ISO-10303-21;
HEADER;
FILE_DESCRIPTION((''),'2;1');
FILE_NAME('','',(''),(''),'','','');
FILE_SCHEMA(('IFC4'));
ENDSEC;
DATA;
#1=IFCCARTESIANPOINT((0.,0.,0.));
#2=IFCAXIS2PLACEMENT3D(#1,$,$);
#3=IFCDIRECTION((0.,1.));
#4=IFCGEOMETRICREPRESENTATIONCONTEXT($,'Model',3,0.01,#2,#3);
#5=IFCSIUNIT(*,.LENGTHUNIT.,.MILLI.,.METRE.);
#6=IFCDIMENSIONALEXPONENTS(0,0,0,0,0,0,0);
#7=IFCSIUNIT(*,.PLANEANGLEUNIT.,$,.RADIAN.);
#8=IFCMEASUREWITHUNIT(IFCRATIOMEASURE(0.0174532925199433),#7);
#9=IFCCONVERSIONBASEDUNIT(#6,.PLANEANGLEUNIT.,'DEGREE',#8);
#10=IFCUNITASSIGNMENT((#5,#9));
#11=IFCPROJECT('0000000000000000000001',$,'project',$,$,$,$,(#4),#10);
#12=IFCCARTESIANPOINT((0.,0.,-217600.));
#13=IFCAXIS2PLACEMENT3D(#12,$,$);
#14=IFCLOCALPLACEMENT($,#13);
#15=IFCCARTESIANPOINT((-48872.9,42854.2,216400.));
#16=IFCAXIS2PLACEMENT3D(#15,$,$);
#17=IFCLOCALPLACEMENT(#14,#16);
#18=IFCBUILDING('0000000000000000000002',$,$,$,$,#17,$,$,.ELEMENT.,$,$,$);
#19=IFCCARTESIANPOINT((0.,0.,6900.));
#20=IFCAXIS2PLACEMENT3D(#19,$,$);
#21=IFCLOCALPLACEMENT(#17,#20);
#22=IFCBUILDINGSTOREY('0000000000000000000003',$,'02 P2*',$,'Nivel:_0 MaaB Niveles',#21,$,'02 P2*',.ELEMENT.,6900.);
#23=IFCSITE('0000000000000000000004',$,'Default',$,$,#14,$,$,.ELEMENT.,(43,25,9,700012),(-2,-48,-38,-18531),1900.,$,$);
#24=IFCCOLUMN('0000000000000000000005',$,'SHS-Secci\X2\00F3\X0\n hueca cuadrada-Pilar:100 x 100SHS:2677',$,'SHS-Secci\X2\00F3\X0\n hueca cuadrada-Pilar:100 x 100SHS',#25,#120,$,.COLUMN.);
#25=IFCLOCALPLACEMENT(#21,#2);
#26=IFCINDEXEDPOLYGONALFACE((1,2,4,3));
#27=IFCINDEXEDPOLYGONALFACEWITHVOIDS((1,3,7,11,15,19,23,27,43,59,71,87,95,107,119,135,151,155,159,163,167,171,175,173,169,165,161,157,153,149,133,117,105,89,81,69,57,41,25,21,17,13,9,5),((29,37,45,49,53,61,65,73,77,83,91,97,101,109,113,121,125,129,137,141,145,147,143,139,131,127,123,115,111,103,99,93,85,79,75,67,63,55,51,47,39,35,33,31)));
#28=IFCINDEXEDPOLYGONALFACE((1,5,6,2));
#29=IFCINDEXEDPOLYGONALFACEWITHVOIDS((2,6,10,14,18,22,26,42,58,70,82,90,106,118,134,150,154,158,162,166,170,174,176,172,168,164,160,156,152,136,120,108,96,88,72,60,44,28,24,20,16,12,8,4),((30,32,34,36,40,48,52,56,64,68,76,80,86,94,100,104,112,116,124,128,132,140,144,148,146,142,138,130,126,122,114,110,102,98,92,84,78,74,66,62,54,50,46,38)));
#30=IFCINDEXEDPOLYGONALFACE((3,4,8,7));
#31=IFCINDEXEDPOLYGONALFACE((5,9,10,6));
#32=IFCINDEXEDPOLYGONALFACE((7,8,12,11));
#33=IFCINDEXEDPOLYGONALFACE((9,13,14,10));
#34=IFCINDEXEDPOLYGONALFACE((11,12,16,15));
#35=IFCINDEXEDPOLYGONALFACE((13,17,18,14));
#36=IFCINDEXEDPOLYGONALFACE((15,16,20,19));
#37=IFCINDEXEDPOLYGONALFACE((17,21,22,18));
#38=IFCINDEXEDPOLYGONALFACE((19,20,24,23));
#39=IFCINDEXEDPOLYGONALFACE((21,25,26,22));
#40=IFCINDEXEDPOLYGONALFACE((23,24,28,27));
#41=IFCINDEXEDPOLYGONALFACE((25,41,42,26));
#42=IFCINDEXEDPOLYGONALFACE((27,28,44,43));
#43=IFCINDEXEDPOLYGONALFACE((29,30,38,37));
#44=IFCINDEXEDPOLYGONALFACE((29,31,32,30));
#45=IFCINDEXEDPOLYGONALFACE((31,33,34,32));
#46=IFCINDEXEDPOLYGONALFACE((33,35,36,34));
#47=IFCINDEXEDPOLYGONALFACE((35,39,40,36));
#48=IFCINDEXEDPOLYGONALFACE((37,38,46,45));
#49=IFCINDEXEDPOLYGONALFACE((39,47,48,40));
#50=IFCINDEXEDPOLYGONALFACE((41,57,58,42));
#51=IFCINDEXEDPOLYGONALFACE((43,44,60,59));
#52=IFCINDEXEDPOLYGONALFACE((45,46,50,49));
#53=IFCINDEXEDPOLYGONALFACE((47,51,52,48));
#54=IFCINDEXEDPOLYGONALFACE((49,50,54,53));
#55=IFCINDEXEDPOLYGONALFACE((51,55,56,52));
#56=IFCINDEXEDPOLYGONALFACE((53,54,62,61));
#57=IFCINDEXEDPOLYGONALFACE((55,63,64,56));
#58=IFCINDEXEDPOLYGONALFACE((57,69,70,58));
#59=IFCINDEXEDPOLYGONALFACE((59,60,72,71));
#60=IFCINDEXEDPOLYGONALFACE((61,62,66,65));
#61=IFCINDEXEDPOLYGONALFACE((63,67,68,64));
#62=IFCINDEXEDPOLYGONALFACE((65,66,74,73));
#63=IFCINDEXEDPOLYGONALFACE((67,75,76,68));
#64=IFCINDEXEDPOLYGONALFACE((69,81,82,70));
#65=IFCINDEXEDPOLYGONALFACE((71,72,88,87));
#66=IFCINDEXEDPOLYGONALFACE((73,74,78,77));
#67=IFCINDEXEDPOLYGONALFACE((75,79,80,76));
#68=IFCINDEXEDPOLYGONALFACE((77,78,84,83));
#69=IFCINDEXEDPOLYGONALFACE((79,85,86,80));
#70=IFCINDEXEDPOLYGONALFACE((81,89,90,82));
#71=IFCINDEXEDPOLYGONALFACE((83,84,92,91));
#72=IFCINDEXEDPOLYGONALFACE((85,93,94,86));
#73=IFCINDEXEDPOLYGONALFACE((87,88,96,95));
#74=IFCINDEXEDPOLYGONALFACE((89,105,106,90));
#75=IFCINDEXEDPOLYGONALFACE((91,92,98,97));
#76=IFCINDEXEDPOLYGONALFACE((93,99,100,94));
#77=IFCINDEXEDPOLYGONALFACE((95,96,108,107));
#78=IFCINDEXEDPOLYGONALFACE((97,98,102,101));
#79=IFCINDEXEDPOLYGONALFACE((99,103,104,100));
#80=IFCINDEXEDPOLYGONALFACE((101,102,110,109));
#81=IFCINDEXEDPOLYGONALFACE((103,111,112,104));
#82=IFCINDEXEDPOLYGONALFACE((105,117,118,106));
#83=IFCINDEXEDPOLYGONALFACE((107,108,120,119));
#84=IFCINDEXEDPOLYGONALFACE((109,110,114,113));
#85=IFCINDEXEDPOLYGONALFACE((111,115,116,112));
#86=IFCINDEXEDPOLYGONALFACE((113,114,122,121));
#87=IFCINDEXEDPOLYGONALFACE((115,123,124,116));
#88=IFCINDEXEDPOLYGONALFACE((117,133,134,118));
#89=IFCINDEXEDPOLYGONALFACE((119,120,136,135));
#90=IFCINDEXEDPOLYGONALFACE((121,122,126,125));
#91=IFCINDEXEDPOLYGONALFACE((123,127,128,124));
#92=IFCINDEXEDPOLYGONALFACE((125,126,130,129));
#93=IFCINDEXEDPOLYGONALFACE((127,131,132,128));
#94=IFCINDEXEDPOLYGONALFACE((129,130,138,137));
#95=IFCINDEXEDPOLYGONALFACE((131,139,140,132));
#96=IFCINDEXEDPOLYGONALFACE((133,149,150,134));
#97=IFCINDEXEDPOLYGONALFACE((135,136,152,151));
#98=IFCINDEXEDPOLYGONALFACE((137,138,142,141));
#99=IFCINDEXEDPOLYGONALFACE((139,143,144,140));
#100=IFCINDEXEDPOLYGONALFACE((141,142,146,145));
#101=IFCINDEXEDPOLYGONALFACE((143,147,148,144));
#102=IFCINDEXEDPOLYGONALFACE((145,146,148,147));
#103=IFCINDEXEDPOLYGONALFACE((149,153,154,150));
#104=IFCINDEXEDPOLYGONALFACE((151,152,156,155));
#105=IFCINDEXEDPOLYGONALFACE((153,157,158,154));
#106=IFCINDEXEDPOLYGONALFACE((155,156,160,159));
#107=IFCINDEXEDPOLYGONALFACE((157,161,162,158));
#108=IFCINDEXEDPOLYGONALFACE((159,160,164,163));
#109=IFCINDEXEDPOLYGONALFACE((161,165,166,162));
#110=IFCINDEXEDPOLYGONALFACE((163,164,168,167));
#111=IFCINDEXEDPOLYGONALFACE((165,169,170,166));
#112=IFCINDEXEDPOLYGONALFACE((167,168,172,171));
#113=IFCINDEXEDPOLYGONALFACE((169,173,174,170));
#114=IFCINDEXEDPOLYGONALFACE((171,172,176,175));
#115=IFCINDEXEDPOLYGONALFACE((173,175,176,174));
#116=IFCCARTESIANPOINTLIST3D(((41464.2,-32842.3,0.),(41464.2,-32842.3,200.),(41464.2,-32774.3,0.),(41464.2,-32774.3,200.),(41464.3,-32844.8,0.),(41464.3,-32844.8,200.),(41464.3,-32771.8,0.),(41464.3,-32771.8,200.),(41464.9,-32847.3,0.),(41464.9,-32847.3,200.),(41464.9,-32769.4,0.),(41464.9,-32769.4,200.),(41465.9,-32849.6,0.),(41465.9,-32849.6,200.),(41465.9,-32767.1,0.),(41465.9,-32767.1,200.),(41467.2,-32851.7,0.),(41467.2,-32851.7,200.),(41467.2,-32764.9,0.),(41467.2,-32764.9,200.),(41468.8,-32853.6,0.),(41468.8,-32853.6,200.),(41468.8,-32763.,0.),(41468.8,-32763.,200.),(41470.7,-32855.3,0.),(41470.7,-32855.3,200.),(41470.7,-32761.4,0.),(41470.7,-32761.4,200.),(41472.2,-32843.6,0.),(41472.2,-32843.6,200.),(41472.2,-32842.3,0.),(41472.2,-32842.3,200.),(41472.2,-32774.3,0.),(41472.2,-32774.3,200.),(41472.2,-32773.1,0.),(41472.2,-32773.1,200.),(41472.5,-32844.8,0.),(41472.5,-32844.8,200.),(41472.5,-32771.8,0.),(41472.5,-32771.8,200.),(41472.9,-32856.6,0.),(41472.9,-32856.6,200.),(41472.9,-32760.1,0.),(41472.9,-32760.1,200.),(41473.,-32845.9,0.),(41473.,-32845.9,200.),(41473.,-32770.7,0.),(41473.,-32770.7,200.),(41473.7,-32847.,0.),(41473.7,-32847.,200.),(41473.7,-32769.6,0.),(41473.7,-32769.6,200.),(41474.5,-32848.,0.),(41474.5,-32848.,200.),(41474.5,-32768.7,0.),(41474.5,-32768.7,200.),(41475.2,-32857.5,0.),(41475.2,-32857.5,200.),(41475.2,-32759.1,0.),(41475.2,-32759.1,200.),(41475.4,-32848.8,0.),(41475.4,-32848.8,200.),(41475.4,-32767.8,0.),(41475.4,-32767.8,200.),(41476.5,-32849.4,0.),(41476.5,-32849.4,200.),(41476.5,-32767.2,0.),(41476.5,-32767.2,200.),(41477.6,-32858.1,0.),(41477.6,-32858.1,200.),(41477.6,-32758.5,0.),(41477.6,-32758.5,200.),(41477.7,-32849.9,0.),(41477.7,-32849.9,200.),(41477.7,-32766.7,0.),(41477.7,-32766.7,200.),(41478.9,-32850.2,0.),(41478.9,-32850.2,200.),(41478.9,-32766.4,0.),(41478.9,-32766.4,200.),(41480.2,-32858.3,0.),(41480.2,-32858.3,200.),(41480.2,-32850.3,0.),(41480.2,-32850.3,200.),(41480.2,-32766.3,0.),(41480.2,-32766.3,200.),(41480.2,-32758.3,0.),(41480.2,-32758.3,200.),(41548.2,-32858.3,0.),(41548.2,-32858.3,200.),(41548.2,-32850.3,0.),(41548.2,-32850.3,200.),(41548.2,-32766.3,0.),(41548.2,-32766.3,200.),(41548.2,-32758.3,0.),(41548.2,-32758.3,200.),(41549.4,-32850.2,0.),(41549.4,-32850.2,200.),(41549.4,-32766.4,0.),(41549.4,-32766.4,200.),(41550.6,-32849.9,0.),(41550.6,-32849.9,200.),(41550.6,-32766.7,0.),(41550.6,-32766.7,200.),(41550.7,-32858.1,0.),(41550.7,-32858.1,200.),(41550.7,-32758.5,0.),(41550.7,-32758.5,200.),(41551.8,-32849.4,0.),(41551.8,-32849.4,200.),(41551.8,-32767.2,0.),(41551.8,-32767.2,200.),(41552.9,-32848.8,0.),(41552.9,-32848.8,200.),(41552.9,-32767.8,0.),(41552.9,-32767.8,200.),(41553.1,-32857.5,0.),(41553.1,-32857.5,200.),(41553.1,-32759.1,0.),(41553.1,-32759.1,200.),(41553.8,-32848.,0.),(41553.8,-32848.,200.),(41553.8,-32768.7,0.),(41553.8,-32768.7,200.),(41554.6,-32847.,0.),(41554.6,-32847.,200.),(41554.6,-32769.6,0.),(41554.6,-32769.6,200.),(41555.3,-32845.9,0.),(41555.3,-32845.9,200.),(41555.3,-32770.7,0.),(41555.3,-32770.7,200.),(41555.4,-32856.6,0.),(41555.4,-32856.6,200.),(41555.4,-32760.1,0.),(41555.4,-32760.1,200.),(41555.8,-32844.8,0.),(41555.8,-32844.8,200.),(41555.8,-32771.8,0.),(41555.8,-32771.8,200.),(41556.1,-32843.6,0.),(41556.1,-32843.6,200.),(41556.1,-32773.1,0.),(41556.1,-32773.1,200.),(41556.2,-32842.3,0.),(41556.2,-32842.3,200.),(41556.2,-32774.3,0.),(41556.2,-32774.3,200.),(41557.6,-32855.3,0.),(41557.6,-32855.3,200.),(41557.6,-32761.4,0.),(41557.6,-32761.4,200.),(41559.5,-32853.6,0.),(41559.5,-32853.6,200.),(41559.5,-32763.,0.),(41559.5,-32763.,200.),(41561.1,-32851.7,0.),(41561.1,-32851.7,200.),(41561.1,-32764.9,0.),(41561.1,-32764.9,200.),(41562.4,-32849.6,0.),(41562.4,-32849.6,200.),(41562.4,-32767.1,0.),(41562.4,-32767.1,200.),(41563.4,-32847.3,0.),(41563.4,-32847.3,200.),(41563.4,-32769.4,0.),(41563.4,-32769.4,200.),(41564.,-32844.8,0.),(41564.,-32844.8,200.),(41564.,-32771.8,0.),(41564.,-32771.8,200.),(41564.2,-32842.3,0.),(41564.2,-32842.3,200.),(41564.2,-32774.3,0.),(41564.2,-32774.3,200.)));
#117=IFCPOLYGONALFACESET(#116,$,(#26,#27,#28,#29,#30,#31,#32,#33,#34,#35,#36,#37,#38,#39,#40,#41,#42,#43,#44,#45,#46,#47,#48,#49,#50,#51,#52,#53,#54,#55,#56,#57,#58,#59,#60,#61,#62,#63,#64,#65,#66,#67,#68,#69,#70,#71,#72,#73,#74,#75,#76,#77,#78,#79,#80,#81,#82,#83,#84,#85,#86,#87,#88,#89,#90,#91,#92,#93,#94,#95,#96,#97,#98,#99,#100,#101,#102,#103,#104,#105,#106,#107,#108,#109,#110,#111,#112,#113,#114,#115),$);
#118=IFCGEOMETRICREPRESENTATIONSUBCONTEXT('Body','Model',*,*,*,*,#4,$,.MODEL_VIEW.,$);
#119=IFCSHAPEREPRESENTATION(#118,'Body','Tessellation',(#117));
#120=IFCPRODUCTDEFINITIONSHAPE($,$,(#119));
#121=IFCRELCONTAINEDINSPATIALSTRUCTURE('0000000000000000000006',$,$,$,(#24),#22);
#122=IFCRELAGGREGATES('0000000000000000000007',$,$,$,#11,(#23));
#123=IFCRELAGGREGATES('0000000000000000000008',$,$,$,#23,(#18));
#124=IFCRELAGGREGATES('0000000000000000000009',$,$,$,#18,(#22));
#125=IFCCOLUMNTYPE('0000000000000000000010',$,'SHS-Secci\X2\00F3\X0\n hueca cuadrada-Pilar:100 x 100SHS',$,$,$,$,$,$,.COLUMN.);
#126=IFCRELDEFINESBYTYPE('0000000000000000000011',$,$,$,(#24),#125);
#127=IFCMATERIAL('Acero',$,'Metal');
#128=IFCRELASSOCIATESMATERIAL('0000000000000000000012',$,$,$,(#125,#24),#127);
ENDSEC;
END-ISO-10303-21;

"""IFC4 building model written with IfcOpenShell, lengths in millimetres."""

from ifc_helpers import new_model, entity, si_unit, converted_unit, direction, frame, origin, place, context, subcontext, project, spatial, indexed_curve, outline, extrude, source, transform, mapped, material, type_object, type_shapes, element, save


model = new_model("IFC4")

# Units and contexts
model_context = context("Model", 3, precision=0.01, world=origin(), true_north=direction((0.0, 1.0)))
body_context = subcontext(model_context, "Body", "Model", "MODEL_VIEW")
ifc_project = project(units=[si_unit("LENGTHUNIT", "METRE", prefix="MILLI"), converted_unit("PLANEANGLEUNIT", "DEGREE", entity("IfcRatioMeasure", 0.0174532925199433), si_unit("PLANEANGLEUNIT", "RADIAN"), dimensions=[0, 0, 0, 0, 0, 0, 0])], contexts=[model_context])

# Site, building, storey
site_placement = place(None, frame((0.0, 0.0, -217600.0)))
site = spatial("IfcSite", under=ifc_project, at=site_placement, Name="Default", CompositionType="ELEMENT", RefLatitude=(43, 25, 9, 700012), RefLongitude=(-2, -48, -38, -18531), RefElevation=1900.0)
building_placement = place(site_placement, frame((-48872.9, 42854.2, 216400.0)))
building = spatial("IfcBuilding", under=site, at=building_placement, CompositionType="ELEMENT")
storey_placement = place(building_placement, frame((0.0, 0.0, 6900.0)))
storey = spatial("IfcBuildingStorey", under=building, at=storey_placement, Name="02 P2*", ObjectType="Nivel:_0 MaaB Niveles", LongName="02 P2*", CompositionType="ELEMENT", Elevation=6900.0)

# Column
ifc_material_1 = material(Name="Acero", Category="Metal")
column_type_1 = type_object("IfcColumnType", Name="SHS-Sección hueca cuadrada-Pilar:100 x 100SHS", PredefinedType="COLUMN", material=ifc_material_1)
shared_shape_1 = source(origin(), body_context, "Body", "SweptSolid", [
    extrude(outline(indexed_curve([(-34.0, -50.0), (34.0, -50.0), (36.5, -49.8), (38.9, -49.2), (41.3, -48.3), (43.4, -46.9), (45.3, -45.3), (46.9, -43.4), (48.3, -41.3), (49.2, -38.9), (49.8, -36.5), (50.0, -34.0), (50.0, 34.0), (49.8, 36.5), (49.2, 38.9), (48.3, 41.3), (46.9, 43.4), (45.3, 45.3), (43.4, 46.9), (41.3, 48.3), (38.9, 49.2), (36.5, 49.8), (34.0, 50.0), (-34.0, 50.0), (-36.5, 49.8), (-38.9, 49.2), (-41.3, 48.3), (-43.4, 46.9), (-45.3, 45.3), (-46.9, 43.4), (-48.3, 41.3), (-49.2, 38.9), (-49.8, 36.5), (-50.0, 34.0), (-50.0, -34.0), (-49.8, -36.5), (-49.2, -38.9), (-48.3, -41.3), (-46.9, -43.4), (-45.3, -45.3), (-43.4, -46.9), (-41.3, -48.3), (-38.9, -49.2), (-36.5, -49.8), (-34.0, -50.0)], self_intersect=False), holes=[indexed_curve([(-42.0, 34.0), (-41.9, 35.3), (-41.6, 36.5), (-41.1, 37.6), (-40.5, 38.7), (-39.7, 39.7), (-38.7, 40.5), (-37.6, 41.1), (-36.5, 41.6), (-35.3, 41.9), (-34.0, 42.0), (34.0, 42.0), (35.3, 41.9), (36.5, 41.6), (37.6, 41.1), (38.7, 40.5), (39.7, 39.7), (40.5, 38.7), (41.1, 37.6), (41.6, 36.5), (41.9, 35.3), (42.0, 34.0), (42.0, -34.0), (41.9, -35.3), (41.6, -36.5), (41.1, -37.6), (40.5, -38.7), (39.7, -39.7), (38.7, -40.5), (37.6, -41.1), (36.5, -41.6), (35.3, -41.9), (34.0, -42.0), (-34.0, -42.0), (-35.3, -41.9), (-36.5, -41.6), (-37.6, -41.1), (-38.7, -40.5), (-39.7, -39.7), (-40.5, -38.7), (-41.1, -37.6), (-41.6, -36.5), (-41.9, -35.3), (-42.0, -34.0), (-42.0, 34.0)], self_intersect=False)]), frame((0.0, 0.0, 6900.0), z_axis=(0.0, 0.0, 1.0), x_axis=(0.0, 1.0, 0.0)), (0.0, 0.0, 1.0), 200.0),
])
type_shapes(column_type_1, [shared_shape_1])
column_1_placement = place(storey_placement, frame((41514.2, -32808.3, -6900.0), z_axis=(0.0, 0.0, 1.0), x_axis=(0.0, -1.0, 0.0)))
element("IfcColumn", 1, at=column_1_placement, inside=storey, type_object=column_type_1, material=ifc_material_1, Name="SHS-Sección hueca cuadrada-Pilar:100 x 100SHS:2677", ObjectType="SHS-Sección hueca cuadrada-Pilar:100 x 100SHS", PredefinedType="COLUMN", context=body_context, shape_type="MappedRepresentation", body=[
    mapped(shared_shape_1, transform((0.0, 0.0, 0.0), scale=1.0)),
])

save(model, "model.ifc")
